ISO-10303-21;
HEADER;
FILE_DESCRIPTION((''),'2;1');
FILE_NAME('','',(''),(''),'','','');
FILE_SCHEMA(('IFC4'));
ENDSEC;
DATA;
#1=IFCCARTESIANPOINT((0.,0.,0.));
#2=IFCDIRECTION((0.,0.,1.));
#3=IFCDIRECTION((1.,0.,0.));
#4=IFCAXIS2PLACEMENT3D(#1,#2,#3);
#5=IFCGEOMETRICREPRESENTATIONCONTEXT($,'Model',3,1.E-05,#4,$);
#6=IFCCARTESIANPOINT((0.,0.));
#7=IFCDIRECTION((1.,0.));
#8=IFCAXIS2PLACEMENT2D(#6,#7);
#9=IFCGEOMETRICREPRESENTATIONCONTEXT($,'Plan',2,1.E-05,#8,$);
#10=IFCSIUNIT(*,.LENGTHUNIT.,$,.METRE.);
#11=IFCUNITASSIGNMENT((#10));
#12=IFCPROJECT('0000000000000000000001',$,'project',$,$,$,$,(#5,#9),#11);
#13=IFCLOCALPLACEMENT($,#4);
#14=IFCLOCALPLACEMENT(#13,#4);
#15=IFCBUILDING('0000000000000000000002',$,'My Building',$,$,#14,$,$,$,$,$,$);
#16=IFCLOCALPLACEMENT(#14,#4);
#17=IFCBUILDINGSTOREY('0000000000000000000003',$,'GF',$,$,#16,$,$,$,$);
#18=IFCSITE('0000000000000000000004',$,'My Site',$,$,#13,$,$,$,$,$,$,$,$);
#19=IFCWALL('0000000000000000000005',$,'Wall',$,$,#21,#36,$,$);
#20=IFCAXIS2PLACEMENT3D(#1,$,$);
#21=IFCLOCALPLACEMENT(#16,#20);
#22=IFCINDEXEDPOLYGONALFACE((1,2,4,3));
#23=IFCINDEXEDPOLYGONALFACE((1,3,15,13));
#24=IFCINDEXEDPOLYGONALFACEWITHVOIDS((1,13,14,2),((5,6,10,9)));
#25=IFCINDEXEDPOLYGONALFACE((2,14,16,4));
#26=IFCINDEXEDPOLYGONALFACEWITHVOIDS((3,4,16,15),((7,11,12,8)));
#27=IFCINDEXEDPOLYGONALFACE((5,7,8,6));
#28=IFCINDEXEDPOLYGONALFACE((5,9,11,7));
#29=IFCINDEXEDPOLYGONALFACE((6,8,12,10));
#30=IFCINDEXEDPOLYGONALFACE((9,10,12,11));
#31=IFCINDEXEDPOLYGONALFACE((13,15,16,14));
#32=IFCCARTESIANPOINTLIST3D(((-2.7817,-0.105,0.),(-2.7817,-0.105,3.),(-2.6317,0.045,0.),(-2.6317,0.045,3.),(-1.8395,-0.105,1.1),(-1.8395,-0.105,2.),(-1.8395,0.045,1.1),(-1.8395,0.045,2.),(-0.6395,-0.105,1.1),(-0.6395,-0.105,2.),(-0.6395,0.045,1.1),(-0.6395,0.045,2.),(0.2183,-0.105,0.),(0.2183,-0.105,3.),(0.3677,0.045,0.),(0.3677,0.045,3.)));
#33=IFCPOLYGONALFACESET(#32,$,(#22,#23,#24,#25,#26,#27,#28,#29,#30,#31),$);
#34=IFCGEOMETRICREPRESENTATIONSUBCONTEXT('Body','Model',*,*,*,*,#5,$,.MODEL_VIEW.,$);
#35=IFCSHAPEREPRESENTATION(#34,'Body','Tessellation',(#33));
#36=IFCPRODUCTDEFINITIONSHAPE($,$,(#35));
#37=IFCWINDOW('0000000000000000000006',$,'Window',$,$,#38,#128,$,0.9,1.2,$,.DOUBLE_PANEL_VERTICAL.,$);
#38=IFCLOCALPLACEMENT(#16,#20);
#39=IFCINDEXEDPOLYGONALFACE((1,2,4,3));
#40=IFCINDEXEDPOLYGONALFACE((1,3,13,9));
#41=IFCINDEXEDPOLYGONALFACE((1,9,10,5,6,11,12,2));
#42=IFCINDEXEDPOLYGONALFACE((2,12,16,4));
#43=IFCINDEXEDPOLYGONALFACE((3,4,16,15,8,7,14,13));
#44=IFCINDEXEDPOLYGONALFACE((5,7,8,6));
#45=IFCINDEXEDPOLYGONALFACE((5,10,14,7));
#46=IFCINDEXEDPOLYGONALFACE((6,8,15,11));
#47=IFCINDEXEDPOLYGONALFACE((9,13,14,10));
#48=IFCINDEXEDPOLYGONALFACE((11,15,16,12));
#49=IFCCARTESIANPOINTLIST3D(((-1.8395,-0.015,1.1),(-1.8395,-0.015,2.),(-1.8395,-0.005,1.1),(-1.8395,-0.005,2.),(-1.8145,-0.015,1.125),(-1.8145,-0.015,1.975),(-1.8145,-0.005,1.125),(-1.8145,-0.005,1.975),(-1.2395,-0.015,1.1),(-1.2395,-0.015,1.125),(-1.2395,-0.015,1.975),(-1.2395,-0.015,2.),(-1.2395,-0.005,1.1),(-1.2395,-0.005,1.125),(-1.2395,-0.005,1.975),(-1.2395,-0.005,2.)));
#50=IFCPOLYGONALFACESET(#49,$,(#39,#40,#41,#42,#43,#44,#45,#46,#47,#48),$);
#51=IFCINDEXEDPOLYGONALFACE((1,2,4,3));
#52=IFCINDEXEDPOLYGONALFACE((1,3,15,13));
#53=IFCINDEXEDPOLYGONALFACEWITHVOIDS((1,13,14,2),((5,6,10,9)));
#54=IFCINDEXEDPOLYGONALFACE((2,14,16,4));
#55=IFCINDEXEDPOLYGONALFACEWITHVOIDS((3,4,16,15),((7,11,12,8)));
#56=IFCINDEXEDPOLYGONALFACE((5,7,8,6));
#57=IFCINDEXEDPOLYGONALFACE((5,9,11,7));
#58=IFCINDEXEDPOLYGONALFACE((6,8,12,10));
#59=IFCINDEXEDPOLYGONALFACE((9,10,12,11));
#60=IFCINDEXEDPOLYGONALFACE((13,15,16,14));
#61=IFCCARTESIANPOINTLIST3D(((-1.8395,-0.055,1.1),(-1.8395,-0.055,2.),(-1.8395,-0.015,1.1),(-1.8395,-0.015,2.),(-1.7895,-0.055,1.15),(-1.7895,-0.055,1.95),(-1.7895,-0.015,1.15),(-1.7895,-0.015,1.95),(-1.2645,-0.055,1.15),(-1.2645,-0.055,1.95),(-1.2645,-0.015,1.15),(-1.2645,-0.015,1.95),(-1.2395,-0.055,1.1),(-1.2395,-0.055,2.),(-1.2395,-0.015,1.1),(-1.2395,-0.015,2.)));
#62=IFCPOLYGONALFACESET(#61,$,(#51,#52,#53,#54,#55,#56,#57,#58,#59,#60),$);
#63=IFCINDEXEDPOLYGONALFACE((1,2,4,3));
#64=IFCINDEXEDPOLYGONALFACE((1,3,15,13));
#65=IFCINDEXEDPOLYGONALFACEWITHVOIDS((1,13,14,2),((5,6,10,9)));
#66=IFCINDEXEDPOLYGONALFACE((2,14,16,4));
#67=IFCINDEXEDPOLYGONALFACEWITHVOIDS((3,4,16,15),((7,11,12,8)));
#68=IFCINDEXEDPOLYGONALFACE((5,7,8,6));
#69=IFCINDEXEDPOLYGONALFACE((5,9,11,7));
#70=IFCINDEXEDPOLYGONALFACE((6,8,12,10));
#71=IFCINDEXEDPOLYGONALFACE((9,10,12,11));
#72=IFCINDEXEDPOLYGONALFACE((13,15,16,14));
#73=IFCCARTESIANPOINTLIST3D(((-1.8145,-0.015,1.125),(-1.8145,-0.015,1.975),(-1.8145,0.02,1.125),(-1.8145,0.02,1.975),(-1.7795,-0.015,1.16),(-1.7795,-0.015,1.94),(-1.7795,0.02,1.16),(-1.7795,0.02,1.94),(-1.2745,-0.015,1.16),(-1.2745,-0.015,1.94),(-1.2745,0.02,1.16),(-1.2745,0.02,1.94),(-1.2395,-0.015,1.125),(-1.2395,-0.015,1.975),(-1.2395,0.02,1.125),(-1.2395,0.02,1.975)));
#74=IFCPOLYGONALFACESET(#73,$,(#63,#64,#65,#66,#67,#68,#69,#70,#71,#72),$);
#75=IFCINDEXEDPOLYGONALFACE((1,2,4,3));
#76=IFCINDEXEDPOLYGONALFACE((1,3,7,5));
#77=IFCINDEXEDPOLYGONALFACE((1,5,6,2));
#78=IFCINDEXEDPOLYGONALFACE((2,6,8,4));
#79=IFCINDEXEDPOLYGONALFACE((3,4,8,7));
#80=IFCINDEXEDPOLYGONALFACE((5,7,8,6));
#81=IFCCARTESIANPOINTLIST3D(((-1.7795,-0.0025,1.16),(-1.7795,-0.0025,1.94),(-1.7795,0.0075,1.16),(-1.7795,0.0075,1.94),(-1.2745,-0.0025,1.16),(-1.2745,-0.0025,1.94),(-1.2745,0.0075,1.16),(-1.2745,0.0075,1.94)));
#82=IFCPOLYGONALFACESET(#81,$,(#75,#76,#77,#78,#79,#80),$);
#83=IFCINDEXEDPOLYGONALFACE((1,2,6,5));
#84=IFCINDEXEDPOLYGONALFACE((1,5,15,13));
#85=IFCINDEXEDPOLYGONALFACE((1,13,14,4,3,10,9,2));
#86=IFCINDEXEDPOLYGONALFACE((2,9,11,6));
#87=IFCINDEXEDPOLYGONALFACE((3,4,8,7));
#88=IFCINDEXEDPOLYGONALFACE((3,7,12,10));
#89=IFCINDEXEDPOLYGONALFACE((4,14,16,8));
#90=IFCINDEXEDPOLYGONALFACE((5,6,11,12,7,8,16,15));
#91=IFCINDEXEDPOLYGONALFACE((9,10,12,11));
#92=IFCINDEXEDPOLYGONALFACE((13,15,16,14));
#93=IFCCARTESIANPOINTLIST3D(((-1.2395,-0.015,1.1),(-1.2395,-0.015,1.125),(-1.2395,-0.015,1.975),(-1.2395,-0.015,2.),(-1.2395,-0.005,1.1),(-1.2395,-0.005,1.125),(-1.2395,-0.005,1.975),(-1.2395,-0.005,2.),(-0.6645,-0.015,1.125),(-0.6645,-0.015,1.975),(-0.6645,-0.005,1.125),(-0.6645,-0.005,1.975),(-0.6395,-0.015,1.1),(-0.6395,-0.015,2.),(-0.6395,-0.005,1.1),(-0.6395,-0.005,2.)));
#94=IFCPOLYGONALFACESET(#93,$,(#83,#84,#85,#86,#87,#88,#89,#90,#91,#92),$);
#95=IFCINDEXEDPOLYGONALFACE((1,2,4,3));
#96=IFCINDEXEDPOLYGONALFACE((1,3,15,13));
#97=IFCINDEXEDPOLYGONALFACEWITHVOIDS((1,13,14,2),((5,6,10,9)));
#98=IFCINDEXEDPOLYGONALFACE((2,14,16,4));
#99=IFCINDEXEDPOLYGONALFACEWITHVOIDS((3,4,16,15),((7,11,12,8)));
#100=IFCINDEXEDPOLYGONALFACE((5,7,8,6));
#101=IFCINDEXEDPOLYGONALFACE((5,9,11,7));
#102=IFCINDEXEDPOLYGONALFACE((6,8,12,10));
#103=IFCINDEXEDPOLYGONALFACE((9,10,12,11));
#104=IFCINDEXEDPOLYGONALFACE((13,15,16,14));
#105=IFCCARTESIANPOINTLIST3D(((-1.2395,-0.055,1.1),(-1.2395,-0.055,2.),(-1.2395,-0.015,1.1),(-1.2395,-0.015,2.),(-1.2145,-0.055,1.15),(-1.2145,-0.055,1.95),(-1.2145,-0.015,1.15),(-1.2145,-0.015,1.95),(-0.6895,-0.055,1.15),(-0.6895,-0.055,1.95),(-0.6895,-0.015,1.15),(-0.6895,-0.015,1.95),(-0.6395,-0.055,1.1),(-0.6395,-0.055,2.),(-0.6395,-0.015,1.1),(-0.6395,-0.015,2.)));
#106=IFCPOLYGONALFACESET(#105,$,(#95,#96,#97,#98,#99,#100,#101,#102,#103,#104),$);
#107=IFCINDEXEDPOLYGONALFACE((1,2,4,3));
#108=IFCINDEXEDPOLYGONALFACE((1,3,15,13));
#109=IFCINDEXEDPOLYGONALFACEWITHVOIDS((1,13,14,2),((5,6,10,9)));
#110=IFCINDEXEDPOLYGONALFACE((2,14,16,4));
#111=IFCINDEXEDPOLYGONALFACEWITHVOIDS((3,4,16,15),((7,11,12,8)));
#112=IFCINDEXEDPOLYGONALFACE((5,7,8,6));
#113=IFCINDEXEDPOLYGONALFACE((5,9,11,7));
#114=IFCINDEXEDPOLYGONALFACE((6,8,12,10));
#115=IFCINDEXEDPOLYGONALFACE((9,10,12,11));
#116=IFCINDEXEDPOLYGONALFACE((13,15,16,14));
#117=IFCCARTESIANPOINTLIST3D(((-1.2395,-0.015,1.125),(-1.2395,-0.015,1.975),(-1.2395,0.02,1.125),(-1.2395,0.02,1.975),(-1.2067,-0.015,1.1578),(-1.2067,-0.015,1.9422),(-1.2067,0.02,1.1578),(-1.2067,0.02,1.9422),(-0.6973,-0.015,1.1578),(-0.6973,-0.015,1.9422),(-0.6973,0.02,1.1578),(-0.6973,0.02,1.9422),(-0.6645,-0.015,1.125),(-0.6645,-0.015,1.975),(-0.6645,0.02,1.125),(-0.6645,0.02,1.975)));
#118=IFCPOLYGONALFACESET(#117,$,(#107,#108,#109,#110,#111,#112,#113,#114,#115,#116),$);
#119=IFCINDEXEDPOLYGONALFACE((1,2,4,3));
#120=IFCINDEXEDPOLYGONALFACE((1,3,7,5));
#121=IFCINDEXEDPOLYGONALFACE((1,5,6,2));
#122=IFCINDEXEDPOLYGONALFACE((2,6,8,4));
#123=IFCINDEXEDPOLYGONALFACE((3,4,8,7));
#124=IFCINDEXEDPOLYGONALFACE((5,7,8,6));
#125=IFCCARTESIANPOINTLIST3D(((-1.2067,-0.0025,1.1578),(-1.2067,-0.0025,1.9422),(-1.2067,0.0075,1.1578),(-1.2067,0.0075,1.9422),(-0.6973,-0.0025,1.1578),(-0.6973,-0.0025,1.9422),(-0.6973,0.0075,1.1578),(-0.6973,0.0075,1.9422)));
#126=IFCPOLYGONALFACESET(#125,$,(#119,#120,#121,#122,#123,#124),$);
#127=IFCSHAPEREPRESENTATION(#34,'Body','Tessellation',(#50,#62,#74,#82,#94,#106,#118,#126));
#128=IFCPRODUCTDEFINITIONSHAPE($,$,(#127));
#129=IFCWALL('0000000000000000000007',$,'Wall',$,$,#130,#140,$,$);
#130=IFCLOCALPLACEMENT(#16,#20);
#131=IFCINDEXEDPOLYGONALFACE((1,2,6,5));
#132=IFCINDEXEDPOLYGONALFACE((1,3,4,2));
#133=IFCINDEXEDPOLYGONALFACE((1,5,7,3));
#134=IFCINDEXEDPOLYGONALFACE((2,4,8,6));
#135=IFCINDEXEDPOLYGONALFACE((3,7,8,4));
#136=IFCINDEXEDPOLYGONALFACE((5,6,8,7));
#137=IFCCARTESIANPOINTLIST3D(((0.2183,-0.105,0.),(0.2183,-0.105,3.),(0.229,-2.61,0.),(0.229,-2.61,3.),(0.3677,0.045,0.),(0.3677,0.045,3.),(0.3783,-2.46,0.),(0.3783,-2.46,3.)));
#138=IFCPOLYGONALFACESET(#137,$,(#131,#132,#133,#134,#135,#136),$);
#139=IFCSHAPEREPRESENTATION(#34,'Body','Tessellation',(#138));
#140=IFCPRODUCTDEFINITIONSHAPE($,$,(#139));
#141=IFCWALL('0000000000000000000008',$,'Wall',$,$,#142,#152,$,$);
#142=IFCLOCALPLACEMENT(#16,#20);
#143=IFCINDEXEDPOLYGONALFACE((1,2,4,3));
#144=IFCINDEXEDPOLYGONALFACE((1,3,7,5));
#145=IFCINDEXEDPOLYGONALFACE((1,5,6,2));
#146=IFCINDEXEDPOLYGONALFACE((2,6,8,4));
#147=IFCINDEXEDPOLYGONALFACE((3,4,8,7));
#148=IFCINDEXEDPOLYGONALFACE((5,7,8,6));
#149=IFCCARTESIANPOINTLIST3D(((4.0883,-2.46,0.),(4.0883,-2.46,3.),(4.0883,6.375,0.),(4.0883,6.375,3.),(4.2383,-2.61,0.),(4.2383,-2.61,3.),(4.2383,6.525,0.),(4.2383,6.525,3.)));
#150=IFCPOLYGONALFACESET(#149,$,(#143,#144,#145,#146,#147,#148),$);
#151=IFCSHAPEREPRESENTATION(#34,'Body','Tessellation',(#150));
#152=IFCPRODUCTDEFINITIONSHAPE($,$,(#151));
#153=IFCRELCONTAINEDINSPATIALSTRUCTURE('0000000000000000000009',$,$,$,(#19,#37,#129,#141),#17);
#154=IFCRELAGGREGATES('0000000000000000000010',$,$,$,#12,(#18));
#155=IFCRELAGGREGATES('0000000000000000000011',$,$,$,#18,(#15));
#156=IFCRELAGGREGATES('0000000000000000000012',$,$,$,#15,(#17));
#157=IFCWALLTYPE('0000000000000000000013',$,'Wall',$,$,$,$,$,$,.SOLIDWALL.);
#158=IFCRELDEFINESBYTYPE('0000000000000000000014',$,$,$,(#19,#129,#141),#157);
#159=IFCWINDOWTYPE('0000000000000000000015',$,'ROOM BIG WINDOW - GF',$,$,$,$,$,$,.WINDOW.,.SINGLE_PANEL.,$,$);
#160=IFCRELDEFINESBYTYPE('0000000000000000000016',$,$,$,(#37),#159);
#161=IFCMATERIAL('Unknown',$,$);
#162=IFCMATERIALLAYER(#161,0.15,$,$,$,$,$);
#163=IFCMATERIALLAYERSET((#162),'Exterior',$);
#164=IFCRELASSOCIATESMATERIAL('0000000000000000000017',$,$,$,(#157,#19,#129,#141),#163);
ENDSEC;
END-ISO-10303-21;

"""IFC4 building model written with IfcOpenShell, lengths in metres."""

from ifc_helpers import new_model, entity, si_unit, frame, origin_with_axes, origin_2d_with_axis, place, context, subcontext, project, spatial, line, indexed_curve, outline, extrude, shape, source, transform, mapped, material, layer, layer_set, layer_usage, type_object, type_shapes, element, fill, save


model = new_model("IFC4")

# Units and contexts
model_context = context("Model", 3, precision=1e-05, world=origin_with_axes())
plan_context = context("Plan", 2, precision=1e-05, world=origin_2d_with_axis())
body_context_1 = subcontext(model_context, "Body", "Model", "MODEL_VIEW")
body_context_2 = subcontext(plan_context, "Body", "Plan", "PLAN_VIEW")
ifc_project = project(units=[si_unit("LENGTHUNIT", "METRE")], contexts=[model_context, plan_context])

# Site, building, storey
site_placement = place(None, origin_with_axes())
site = spatial("IfcSite", under=ifc_project, at=site_placement, Name="My Site")
building_placement = place(site_placement, origin_with_axes())
building = spatial("IfcBuilding", under=site, at=building_placement, Name="My Building")
storey_placement = place(building_placement, origin_with_axes())
storey = spatial("IfcBuildingStorey", under=building, at=storey_placement, Name="GF")

# Shared definitions
ifc_material = material(Name="Unknown")

# Shared definitions
ifc_layer_1 = layer(ifc_material, 0.15)
ifc_layer_set_1 = layer_set([ifc_layer_1], Name="Exterior")
wall_type_1 = type_object("IfcWallType", Name="Wall", PredefinedType="SOLIDWALL", material=ifc_layer_set_1)

# Wall, opening, window
shared_shape_1 = source(origin_with_axes(), body_context_1, "Body", "SweptSolid", [
    extrude(outline(indexed_curve([(0.0, 0.0), (1.2, 0.0), (1.2, 0.9), (0.0, 0.9)], segments=[line(1, 2, 3, 4, 1)])), frame((0.0, -0.6, 0.0), z_axis=(0.0, -1.0, 0.0), x_axis=(1.0, 0.0, 0.0)), (0.0, 0.0, -1.0), 1.2),
])
window_type_1 = type_object("IfcWindowType", Name="ROOM BIG WINDOW - GF", PartitioningType="SINGLE_PANEL", PredefinedType="WINDOW")
shared_shape_2 = source(origin_with_axes(), body_context_1, "Body", "SweptSolid", [
    extrude(outline(indexed_curve([(0.6, 0.0), (0.0, 0.0), (0.0, 0.9), (0.6, 0.9), (0.6, 0.875), (0.025, 0.875), (0.025, 0.025), (0.6, 0.025)], segments=[line(1, 2, 3, 4, 5, 6, 7, 8, 1)])), frame((0.0, 0.09, 0.0), z_axis=(0.0, -1.0, 0.0), x_axis=(1.0, 0.0, 0.0)), (0.0, 0.0, -1.0), 0.01),
    extrude(outline(indexed_curve([(0.0, 0.0), (0.6, 0.0), (0.6, 0.9), (0.0, 0.9)], segments=[line(1, 2, 3, 4, 1)]), holes=[indexed_curve([(0.05, 0.05), (0.575, 0.05), (0.575, 0.85), (0.05, 0.85)], segments=[line(1, 2, 3, 4, 1)])]), frame((0.0, 0.05, 0.0), z_axis=(0.0, -1.0, 0.0), x_axis=(1.0, 0.0, 0.0)), (0.0, 0.0, -1.0), 0.04),
    extrude(outline(indexed_curve([(0.0, 0.0), (0.575, 0.0), (0.575, 0.85), (0.0, 0.85)], segments=[line(1, 2, 3, 4, 1)]), holes=[indexed_curve([(0.035, 0.035), (0.54, 0.035), (0.54, 0.815), (0.035, 0.815)], segments=[line(1, 2, 3, 4, 1)])]), frame((0.025, 0.09, 0.025), z_axis=(0.0, -1.0, 0.0), x_axis=(1.0, 0.0, 0.0)), (0.0, 0.0, -1.0), 0.035),
    extrude(outline(indexed_curve([(0.035, 0.035), (0.54, 0.035), (0.54, 0.815), (0.035, 0.815)], segments=[line(1, 2, 3, 4, 1)])), frame((0.025, 0.1025, 0.025), z_axis=(0.0, -1.0, 0.0), x_axis=(1.0, 0.0, 0.0)), (0.0, 0.0, -1.0), 0.01),
    extrude(outline(indexed_curve([(0.0, 0.9), (0.6, 0.9), (0.6, 0.0), (0.0, 0.0), (0.0, 0.025), (0.575, 0.025), (0.575, 0.875), (0.0, 0.875)], segments=[line(1, 2, 3, 4, 5, 6, 7, 8, 1)])), frame((0.6, 0.09, 0.0), z_axis=(0.0, -1.0, 0.0), x_axis=(1.0, 0.0, 0.0)), (0.0, 0.0, -1.0), 0.01),
    extrude(outline(indexed_curve([(0.0, 0.0), (0.6, 0.0), (0.6, 0.9), (0.0, 0.9)], segments=[line(1, 2, 3, 4, 1)]), holes=[indexed_curve([(0.025, 0.05), (0.55, 0.05), (0.55, 0.85), (0.025, 0.85)], segments=[line(1, 2, 3, 4, 1)])]), frame((0.6, 0.05, 0.0), z_axis=(0.0, -1.0, 0.0), x_axis=(1.0, 0.0, 0.0)), (0.0, 0.0, -1.0), 0.04),
    extrude(outline(indexed_curve([(0.0, 0.0), (0.575, 0.0), (0.575, 0.85), (0.0, 0.85)], segments=[line(1, 2, 3, 4, 1)]), holes=[indexed_curve([(0.0328, 0.0328), (0.5422, 0.0328), (0.5422, 0.8172), (0.0328, 0.8172)], segments=[line(1, 2, 3, 4, 1)])]), frame((0.6, 0.09, 0.025), z_axis=(0.0, -1.0, 0.0), x_axis=(1.0, 0.0, 0.0)), (0.0, 0.0, -1.0), 0.035),
    extrude(outline(indexed_curve([(0.0328, 0.0328), (0.5422, 0.0328), (0.5422, 0.8172), (0.0328, 0.8172)], segments=[line(1, 2, 3, 4, 1)])), frame((0.6, 0.1025, 0.025), z_axis=(0.0, -1.0, 0.0), x_axis=(1.0, 0.0, 0.0)), (0.0, 0.0, -1.0), 0.01),
])
shared_shape_3 = source(origin_with_axes(), body_context_2, "Body", "Curve2D", [
    entity("IfcIndexedPolyCurve", entity("IfcCartesianPointList2D", [[0.05, 0.05], [0.575, 0.05]])),
    entity("IfcIndexedPolyCurve", entity("IfcCartesianPointList2D", [[0.0, 0.1], [0.025, 0.1], [0.025, 0.09], [0.05, 0.09], [0.05, 0.05], [0.0, 0.05]]), [entity("IfcLineIndex", [1, 2, 3, 4, 5, 6, 1])]),
    entity("IfcIndexedPolyCurve", entity("IfcCartesianPointList2D", [[0.6, 0.1], [0.6, 0.1], [0.6, 0.09], [0.575, 0.09], [0.575, 0.05], [0.6, 0.05]])),
    entity("IfcIndexedPolyCurve", entity("IfcCartesianPointList2D", [[0.025, 0.09], [0.06, 0.09], [0.06, 0.125], [0.025, 0.125]]), [entity("IfcLineIndex", [1, 2, 3, 4, 1])]),
    entity("IfcIndexedPolyCurve", entity("IfcCartesianPointList2D", [[0.6, 0.09], [0.565, 0.09], [0.565, 0.125], [0.6, 0.125]]), [entity("IfcLineIndex", [1, 2, 3, 4, 1])]),
    entity("IfcIndexedPolyCurve", entity("IfcCartesianPointList2D", [[0.06, 0.09], [0.565, 0.09]])),
    entity("IfcIndexedPolyCurve", entity("IfcCartesianPointList2D", [[0.06, 0.125], [0.565, 0.125]])),
    entity("IfcIndexedPolyCurve", entity("IfcCartesianPointList2D", [[0.06, 0.1075], [0.565, 0.1075]])),
    entity("IfcIndexedPolyCurve", entity("IfcCartesianPointList2D", [[0.625, 0.05], [1.15, 0.05]])),
    entity("IfcIndexedPolyCurve", entity("IfcCartesianPointList2D", [[0.6, 0.1], [0.6, 0.1], [0.6, 0.09], [0.625, 0.09], [0.625, 0.05], [0.6, 0.05]])),
    entity("IfcIndexedPolyCurve", entity("IfcCartesianPointList2D", [[1.2, 0.1], [1.175, 0.1], [1.175, 0.09], [1.15, 0.09], [1.15, 0.05], [1.2, 0.05]]), [entity("IfcLineIndex", [1, 2, 3, 4, 5, 6, 1])]),
    entity("IfcIndexedPolyCurve", entity("IfcCartesianPointList2D", [[0.6, 0.09], [0.6328, 0.09], [0.6328, 0.125], [0.6, 0.125]]), [entity("IfcLineIndex", [1, 2, 3, 4, 1])]),
    entity("IfcIndexedPolyCurve", entity("IfcCartesianPointList2D", [[1.175, 0.09], [1.1422, 0.09], [1.1422, 0.125], [1.175, 0.125]]), [entity("IfcLineIndex", [1, 2, 3, 4, 1])]),
    entity("IfcIndexedPolyCurve", entity("IfcCartesianPointList2D", [[0.6328, 0.09], [1.1422, 0.09]])),
    entity("IfcIndexedPolyCurve", entity("IfcCartesianPointList2D", [[0.6328, 0.125], [1.1422, 0.125]])),
    entity("IfcIndexedPolyCurve", entity("IfcCartesianPointList2D", [[0.6328, 0.1075], [1.1422, 0.1075]])),
])
type_shapes(window_type_1, [shared_shape_2, shared_shape_3])
ifc_layer_usage_1 = layer_usage(ifc_layer_set_1, "AXIS2", "POSITIVE", 0.0)
wall_1_placement = place(storey_placement, frame((-2.7817, -0.105, 0.0), z_axis=(0.0, 0.0, 1.0), x_axis=(1.0, 0.0, 0.0)))
wall_1 = element("IfcWall", 1, at=wall_1_placement, inside=storey, type_object=wall_type_1, material=ifc_layer_usage_1, Name="Wall", context=body_context_1, shape_type="SweptSolid", body=[
    extrude(outline(indexed_curve([(0.0, 0.0), (0.15, 0.15), (3.1494, 0.15), (3.0, 0.0)], segments=[line(1, 2, 3, 4, 1)])), origin_with_axes(), (0.0, 0.0, 1.0), 3.0),
])
opening_1_placement = place(wall_1_placement, frame((0.9421, 0.0, 1.1), z_axis=(0.0, 0.0, 1.0), x_axis=(1.0, 0.0, 0.0)))
opening_1 = element("IfcOpeningElement", 2, at=opening_1_placement, cuts=wall_1, PredefinedType="OPENING", context=body_context_1, shape_type="MappedRepresentation", body=[
    mapped(shared_shape_1, transform((0.0, 0.0, 0.0), x_axis=(1.0, 0.0, 0.0), y_axis=(0.0, 1.0, 0.0), z_axis=(0.0, 0.0, 1.0), scale=1.0)),
])
window_1_placement = place(opening_1_placement, frame((0.0, 0.0, 0.0), z_axis=(0.0, 0.0, 1.0), x_axis=(1.0, 0.0, 0.0)))
window_1 = element("IfcWindow", 3, at=window_1_placement, inside=storey, type_object=window_type_1, Name="Window", OverallHeight=0.9, OverallWidth=1.2, PartitioningType="DOUBLE_PANEL_VERTICAL", shapes=[
    shape(body_context_1, "Body", "MappedRepresentation", [mapped(shared_shape_2, transform((0.0, 0.0, 0.0), x_axis=(1.0, 0.0, 0.0), y_axis=(0.0, 1.0, 0.0), z_axis=(0.0, 0.0, 1.0), scale=1.0))]),
    shape(body_context_2, "Body", "MappedRepresentation", [mapped(shared_shape_3, transform((0.0, 0.0, 0.0), x_axis=(1.0, 0.0, 0.0), y_axis=(0.0, 1.0, 0.0), z_axis=(0.0, 0.0, 1.0), scale=1.0))]),
])
fill(opening_1, window_1)

# Walls
ifc_layer_usage_2 = layer_usage(ifc_layer_set_1, "AXIS2", "POSITIVE", 0.0)
wall_2_placement = place(storey_placement, frame((0.2183, -0.105, 0.0), z_axis=(0.0, 0.0, 1.0), x_axis=(0.004245, -0.999991, 0.0)))
element("IfcWall", 4, at=wall_2_placement, inside=storey, type_object=wall_type_1, material=ifc_layer_usage_2, Name="Wall", context=body_context_1, shape_type="SweptSolid", body=[
    extrude(outline(indexed_curve([(0.0, 0.0), (-0.1494, 0.15), (2.3557, 0.15), (2.505, 0.0)], segments=[line(1, 2, 3, 4, 1)])), origin_with_axes(), (0.0, 0.0, 1.0), 3.0),
])
ifc_layer_usage_3 = layer_usage(ifc_layer_set_1, "AXIS2", "POSITIVE", 0.0)
wall_3_placement = place(storey_placement, frame((4.2383, -2.61, 0.0), z_axis=(0.0, 0.0, 1.0), x_axis=(0.0, 1.0, 0.0)))
element("IfcWall", 5, at=wall_3_placement, inside=storey, type_object=wall_type_1, material=ifc_layer_usage_3, Name="Wall", context=body_context_1, shape_type="SweptSolid", body=[
    extrude(outline(indexed_curve([(0.0, 0.0), (0.15, 0.15), (8.985, 0.15), (9.135, 0.0)], segments=[line(1, 2, 3, 4, 1)])), origin_with_axes(), (0.0, 0.0, 1.0), 3.0),
])

save(model, "model.ifc")
